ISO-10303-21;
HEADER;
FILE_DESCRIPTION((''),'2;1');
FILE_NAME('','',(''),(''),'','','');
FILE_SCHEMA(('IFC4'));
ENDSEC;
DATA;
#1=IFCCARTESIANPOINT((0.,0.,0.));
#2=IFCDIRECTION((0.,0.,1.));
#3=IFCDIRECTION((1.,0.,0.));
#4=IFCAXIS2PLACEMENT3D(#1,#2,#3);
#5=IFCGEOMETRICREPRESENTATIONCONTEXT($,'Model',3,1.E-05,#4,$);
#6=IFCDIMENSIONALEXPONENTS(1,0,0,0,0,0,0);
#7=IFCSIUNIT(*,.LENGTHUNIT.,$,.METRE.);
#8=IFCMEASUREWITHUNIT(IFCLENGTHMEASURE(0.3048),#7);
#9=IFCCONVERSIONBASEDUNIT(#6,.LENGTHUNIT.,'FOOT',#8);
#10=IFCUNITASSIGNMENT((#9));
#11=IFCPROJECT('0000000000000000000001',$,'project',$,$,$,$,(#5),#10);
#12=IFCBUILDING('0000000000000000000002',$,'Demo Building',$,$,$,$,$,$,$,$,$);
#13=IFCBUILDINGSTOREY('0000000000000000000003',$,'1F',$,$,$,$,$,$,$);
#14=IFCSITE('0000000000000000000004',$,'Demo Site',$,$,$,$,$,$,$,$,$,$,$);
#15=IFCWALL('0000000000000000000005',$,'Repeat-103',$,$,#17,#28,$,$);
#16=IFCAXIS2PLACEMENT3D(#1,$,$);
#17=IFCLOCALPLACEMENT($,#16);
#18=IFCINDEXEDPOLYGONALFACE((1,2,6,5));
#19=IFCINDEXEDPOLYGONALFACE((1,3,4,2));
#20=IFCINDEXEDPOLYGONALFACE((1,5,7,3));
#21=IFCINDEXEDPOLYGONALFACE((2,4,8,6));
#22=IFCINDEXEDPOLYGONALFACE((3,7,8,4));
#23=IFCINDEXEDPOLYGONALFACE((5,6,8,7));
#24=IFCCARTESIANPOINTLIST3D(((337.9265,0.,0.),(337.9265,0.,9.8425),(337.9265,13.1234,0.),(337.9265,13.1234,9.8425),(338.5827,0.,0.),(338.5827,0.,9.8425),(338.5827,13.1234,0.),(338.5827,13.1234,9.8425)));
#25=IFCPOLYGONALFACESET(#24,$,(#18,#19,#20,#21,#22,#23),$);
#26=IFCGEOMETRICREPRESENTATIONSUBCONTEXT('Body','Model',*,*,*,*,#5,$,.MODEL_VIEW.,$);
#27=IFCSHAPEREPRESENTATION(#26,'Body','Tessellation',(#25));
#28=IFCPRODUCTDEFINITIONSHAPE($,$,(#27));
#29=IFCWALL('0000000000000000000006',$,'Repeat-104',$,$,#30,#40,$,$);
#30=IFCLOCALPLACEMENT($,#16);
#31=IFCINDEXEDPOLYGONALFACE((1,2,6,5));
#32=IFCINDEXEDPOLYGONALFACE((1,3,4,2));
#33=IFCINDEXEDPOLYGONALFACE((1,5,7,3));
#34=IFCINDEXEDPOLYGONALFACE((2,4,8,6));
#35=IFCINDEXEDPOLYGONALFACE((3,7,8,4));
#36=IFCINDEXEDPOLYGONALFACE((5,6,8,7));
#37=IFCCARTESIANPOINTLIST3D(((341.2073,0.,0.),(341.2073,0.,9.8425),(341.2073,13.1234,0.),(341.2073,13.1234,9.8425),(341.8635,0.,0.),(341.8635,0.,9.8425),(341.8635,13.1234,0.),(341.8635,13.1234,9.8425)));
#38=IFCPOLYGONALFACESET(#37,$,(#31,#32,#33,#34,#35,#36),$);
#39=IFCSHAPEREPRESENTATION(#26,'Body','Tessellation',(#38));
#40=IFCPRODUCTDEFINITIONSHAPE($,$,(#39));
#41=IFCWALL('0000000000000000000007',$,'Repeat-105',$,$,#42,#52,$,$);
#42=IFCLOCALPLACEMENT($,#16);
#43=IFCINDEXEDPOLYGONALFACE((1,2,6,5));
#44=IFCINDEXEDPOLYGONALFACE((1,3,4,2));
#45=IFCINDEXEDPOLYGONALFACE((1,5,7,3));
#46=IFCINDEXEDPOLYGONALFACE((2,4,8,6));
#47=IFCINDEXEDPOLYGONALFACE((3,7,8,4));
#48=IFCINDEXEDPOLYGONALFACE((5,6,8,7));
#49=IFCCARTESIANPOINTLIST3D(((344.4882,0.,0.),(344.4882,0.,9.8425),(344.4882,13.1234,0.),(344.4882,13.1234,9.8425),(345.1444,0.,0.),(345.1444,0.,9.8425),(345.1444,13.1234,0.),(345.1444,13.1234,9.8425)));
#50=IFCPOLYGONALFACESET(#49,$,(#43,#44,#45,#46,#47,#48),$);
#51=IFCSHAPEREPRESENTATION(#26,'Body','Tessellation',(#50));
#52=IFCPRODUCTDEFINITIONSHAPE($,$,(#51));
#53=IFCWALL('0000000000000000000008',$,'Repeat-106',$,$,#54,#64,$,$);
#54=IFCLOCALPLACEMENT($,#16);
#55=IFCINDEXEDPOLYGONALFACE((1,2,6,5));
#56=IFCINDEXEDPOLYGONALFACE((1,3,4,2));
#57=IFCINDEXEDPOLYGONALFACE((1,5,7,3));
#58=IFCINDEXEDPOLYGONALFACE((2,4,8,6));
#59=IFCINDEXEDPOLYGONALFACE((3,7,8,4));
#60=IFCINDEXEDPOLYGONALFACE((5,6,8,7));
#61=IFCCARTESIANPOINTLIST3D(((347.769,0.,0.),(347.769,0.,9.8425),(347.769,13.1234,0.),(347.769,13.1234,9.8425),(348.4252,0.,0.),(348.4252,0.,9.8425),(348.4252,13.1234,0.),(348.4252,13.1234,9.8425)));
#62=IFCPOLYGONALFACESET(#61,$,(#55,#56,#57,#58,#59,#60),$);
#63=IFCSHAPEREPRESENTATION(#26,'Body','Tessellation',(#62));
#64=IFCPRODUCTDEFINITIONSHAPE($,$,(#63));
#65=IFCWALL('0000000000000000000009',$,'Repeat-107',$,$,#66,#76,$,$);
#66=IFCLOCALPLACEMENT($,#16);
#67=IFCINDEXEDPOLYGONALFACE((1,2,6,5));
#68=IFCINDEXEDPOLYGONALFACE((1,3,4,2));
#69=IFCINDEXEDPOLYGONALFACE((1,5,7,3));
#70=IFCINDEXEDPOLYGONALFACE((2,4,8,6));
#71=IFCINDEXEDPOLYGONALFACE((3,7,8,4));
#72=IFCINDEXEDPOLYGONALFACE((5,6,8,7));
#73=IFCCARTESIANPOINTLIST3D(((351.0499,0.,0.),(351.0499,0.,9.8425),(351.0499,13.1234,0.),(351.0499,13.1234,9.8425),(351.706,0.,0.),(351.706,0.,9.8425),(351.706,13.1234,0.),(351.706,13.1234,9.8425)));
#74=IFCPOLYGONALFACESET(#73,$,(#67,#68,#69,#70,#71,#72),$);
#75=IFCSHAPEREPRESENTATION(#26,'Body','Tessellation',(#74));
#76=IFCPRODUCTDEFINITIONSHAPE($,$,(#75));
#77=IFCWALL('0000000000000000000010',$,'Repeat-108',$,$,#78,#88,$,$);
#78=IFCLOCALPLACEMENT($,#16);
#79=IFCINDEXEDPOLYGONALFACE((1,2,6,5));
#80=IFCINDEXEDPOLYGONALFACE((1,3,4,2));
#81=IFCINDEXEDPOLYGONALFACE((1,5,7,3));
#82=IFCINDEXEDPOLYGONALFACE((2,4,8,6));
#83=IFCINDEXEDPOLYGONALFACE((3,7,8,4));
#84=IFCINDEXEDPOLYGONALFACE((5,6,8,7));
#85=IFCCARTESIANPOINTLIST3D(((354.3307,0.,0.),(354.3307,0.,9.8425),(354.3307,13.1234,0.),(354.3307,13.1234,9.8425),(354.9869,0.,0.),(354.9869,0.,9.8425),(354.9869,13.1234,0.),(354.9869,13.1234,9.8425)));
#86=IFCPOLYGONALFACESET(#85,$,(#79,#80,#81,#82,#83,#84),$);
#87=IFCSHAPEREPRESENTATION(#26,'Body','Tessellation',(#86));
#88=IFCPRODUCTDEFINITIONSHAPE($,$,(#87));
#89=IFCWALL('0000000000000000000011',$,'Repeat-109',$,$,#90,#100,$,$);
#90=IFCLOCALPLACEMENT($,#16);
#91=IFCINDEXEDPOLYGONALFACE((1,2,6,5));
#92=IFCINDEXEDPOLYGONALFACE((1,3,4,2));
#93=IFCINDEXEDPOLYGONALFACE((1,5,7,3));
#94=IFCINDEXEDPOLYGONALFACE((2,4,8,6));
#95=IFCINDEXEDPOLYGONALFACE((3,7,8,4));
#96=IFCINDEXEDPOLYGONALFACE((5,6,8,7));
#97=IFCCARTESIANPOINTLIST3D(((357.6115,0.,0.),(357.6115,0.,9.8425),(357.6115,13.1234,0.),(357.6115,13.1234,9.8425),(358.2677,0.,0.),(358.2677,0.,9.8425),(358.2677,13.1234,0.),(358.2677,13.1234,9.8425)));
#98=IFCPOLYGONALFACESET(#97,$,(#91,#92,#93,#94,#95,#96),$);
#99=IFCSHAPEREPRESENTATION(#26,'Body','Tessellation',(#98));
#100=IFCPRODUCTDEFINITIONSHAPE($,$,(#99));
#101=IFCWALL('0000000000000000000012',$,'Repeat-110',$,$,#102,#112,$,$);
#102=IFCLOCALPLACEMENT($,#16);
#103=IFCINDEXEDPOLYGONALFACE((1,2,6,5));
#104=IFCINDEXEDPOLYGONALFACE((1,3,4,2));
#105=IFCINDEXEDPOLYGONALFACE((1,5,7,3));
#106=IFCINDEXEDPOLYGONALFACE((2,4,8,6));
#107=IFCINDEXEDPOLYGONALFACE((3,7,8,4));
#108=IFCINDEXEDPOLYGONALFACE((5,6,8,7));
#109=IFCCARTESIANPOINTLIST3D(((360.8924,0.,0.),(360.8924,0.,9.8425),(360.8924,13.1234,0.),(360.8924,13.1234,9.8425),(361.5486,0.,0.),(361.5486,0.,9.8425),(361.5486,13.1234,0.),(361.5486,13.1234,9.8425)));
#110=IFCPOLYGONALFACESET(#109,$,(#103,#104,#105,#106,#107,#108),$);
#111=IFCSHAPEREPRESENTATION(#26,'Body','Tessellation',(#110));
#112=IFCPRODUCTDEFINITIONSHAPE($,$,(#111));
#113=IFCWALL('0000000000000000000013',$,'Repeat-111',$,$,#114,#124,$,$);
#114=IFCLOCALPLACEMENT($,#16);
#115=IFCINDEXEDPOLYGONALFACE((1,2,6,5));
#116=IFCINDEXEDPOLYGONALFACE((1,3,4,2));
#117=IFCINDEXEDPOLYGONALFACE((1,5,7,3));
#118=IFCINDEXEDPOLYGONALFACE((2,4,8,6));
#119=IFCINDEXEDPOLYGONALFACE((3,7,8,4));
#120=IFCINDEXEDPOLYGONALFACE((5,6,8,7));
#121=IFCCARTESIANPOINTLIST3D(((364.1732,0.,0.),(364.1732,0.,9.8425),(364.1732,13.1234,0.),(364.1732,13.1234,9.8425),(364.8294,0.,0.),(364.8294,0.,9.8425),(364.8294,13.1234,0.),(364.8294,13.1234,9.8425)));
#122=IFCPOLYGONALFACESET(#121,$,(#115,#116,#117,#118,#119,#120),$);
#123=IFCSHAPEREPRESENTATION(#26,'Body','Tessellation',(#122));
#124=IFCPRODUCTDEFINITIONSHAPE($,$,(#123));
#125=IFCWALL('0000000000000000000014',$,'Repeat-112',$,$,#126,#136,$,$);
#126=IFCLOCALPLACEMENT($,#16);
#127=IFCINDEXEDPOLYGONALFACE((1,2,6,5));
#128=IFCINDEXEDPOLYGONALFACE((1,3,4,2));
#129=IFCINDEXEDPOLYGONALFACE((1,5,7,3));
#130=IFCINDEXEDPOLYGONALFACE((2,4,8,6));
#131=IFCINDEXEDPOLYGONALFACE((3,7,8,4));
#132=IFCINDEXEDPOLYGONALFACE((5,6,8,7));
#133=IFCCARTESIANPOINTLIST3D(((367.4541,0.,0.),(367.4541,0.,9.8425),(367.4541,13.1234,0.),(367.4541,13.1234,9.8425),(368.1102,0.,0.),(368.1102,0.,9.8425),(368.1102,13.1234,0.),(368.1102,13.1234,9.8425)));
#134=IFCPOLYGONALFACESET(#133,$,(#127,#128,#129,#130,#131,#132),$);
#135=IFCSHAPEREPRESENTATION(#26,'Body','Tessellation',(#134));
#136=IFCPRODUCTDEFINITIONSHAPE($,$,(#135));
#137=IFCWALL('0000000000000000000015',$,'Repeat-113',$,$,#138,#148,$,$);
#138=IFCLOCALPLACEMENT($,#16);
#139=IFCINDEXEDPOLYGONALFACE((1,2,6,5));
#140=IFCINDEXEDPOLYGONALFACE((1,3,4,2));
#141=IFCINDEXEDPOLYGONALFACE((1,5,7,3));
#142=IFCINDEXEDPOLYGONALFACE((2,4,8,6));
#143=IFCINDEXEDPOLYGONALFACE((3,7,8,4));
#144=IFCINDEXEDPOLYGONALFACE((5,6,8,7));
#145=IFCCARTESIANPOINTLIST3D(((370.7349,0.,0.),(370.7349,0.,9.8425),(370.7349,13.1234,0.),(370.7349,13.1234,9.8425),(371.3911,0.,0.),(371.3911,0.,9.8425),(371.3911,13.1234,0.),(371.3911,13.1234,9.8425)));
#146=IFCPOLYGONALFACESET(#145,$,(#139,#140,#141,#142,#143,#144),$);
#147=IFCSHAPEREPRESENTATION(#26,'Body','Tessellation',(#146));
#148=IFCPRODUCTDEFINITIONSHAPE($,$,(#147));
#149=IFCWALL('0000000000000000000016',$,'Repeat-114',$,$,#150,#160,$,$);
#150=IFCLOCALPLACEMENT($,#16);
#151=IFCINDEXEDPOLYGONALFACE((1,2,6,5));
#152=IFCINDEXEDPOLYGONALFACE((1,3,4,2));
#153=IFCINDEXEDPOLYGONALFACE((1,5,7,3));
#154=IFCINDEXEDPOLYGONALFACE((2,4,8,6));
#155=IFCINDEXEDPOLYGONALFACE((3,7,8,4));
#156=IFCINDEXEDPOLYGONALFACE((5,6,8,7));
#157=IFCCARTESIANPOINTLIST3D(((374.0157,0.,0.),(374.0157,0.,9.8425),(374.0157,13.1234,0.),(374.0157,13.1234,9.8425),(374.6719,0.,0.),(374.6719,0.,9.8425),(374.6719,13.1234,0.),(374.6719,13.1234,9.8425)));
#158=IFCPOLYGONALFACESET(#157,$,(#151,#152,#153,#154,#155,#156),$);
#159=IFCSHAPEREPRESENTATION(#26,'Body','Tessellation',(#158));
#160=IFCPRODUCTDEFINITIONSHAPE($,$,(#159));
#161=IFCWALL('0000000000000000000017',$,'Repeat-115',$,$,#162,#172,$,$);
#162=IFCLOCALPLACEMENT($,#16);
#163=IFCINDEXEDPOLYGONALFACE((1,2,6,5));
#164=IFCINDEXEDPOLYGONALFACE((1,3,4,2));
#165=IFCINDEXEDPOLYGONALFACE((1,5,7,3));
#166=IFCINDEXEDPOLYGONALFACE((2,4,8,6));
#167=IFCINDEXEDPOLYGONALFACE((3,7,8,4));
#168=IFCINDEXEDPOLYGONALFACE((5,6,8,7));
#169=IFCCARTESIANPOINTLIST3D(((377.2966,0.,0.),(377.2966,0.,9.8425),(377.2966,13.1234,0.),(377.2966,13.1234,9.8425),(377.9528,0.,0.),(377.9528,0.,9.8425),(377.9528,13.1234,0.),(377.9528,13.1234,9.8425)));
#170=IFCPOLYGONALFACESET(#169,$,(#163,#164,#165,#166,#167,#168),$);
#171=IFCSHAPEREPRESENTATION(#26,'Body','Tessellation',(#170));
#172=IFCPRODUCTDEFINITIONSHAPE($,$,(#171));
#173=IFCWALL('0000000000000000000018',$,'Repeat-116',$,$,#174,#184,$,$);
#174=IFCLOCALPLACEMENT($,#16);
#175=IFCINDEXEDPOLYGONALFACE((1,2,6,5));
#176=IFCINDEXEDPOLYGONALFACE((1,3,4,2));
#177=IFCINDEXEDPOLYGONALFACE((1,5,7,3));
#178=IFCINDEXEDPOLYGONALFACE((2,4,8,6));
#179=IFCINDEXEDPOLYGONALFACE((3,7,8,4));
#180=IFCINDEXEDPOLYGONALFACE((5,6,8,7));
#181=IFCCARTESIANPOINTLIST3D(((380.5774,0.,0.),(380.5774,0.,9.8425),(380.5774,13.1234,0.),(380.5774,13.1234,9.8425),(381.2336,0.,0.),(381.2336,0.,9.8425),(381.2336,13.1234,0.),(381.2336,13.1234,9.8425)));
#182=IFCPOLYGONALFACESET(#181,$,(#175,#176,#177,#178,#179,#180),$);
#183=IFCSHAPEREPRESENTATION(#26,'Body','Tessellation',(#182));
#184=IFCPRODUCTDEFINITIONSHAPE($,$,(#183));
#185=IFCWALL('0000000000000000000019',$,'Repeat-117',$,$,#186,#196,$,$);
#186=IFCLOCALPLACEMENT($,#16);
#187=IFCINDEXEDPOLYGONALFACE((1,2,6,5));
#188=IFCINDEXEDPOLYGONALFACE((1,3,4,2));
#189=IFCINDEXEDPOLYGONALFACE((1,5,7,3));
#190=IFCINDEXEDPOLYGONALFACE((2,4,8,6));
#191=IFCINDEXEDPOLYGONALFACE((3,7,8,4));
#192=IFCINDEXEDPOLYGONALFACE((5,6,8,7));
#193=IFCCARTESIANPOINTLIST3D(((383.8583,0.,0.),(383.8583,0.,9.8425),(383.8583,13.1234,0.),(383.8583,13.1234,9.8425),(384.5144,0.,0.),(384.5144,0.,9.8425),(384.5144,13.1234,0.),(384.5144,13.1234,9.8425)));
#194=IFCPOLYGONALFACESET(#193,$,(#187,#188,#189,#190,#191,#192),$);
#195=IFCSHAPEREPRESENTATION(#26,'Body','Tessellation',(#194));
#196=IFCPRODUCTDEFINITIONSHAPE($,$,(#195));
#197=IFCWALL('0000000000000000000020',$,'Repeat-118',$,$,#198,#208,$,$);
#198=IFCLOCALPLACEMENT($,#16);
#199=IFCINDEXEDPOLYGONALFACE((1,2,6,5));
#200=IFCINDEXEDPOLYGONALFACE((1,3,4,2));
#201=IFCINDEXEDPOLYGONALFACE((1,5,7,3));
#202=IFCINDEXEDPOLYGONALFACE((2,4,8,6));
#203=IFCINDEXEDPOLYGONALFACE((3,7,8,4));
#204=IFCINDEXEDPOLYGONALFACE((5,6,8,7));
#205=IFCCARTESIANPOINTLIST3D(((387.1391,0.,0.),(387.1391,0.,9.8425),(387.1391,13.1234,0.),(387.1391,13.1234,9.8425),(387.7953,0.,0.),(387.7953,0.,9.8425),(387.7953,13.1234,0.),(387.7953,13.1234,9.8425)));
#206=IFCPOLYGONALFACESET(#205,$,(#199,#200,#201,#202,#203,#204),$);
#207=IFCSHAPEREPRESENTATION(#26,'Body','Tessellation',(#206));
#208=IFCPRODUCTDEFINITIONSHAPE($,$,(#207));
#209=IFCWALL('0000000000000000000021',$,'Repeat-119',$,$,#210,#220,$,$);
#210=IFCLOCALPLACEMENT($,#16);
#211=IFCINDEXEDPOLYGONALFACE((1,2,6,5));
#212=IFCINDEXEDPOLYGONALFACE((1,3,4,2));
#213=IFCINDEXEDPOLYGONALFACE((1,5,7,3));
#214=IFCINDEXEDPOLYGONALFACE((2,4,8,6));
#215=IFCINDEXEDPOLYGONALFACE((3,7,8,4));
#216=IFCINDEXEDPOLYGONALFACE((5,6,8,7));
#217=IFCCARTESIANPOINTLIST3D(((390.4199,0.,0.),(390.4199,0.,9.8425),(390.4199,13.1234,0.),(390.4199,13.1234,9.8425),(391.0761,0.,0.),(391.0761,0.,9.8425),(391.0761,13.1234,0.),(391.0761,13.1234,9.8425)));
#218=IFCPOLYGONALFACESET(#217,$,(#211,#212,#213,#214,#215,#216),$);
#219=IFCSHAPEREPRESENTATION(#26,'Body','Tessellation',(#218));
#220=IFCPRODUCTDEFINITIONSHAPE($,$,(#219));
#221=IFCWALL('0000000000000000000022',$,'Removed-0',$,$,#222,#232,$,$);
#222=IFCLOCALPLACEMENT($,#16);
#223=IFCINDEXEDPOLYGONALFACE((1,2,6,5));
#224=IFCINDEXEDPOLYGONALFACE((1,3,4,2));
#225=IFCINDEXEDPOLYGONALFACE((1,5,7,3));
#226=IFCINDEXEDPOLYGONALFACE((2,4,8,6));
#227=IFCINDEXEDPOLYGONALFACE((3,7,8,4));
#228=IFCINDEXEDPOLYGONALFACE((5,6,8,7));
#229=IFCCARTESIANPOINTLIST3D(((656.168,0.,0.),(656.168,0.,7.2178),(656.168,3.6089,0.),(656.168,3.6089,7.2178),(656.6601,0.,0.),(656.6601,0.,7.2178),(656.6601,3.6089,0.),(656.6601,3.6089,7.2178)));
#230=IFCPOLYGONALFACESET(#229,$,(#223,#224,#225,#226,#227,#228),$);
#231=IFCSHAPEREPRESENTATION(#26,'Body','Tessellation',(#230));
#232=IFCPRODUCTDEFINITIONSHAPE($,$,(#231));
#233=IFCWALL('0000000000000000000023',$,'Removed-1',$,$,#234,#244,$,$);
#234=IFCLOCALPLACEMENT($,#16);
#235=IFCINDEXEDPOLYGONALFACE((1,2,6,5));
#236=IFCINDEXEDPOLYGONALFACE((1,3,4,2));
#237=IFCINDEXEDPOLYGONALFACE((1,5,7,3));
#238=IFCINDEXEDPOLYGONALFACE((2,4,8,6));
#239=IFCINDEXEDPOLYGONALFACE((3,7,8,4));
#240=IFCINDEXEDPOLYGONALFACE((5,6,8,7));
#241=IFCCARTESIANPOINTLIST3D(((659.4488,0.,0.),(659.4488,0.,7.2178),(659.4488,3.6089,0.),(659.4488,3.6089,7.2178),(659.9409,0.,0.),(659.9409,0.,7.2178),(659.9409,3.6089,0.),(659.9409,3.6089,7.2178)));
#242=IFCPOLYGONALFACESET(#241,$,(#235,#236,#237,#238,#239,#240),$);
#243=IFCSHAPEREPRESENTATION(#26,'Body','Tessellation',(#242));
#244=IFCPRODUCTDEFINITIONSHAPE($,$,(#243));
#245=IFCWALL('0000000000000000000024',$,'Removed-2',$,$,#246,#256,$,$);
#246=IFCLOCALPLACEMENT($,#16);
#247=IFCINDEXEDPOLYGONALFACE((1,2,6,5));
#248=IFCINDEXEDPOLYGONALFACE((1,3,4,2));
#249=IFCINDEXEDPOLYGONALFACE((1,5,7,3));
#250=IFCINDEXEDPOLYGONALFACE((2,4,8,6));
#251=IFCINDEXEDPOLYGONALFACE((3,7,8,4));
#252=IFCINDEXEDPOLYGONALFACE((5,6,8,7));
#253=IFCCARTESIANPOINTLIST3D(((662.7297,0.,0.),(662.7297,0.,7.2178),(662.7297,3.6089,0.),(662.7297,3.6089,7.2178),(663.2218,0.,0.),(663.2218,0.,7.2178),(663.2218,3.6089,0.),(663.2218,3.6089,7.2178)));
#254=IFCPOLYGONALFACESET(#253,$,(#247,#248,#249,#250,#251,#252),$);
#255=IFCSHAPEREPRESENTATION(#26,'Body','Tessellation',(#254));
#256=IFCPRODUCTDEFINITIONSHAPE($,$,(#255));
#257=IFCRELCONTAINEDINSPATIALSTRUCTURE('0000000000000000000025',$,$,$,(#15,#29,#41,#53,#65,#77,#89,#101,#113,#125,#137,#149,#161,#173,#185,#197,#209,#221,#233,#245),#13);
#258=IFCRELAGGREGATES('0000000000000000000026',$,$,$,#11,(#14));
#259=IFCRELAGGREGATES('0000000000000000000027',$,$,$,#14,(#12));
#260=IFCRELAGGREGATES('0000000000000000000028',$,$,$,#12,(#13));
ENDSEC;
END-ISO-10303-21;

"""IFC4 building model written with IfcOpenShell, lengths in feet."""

from ifc_helpers import new_model, entity, si_unit, converted_unit, frame, origin_with_axes, place, context, subcontext, project, spatial, element, save


model = new_model("IFC4")

# Units and contexts
model_context = context("Model", 3, precision=1e-05, world=origin_with_axes())
body_context = subcontext(model_context, "Body", "Model", "MODEL_VIEW")
ifc_project = project(units=[converted_unit("LENGTHUNIT", "FOOT", entity("IfcLengthMeasure", 0.3048), si_unit("LENGTHUNIT", "METRE"), dimensions=[1, 0, 0, 0, 0, 0, 0])], contexts=[model_context])

# Site, building, storey
site = spatial("IfcSite", under=ifc_project, Name="Demo Site")
building = spatial("IfcBuilding", under=site, Name="Demo Building")
storey = spatial("IfcBuildingStorey", under=building, Name="1F")

# Walls
for number, where, z_axis, x_axis, name in (
    (1, (337.9265, 0.0, 0.0), (0.0, 0.0, 1.0), (1.0, 0.0, 0.0), "Repeat-103"),
    (2, (341.2073, 0.0, 0.0), (0.0, 0.0, 1.0), (1.0, 0.0, 0.0), "Repeat-104"),
    (3, (344.4882, 0.0, 0.0), (0.0, 0.0, 1.0), (1.0, 0.0, 0.0), "Repeat-105"),
    (4, (347.769, 0.0, 0.0), (0.0, 0.0, 1.0), (1.0, 0.0, 0.0), "Repeat-106"),
    (5, (351.0499, 0.0, 0.0), (0.0, 0.0, 1.0), (1.0, 0.0, 0.0), "Repeat-107"),
    (6, (354.3307, 0.0, 0.0), (0.0, 0.0, 1.0), (1.0, 0.0, 0.0), "Repeat-108"),
    (7, (357.6115, 0.0, 0.0), (0.0, 0.0, 1.0), (1.0, 0.0, 0.0), "Repeat-109"),
    (8, (360.8924, 0.0, 0.0), (0.0, 0.0, 1.0), (1.0, 0.0, 0.0), "Repeat-110"),
    (9, (364.1732, 0.0, 0.0), (0.0, 0.0, 1.0), (1.0, 0.0, 0.0), "Repeat-111"),
    (10, (367.4541, 0.0, 0.0), (0.0, 0.0, 1.0), (1.0, 0.0, 0.0), "Repeat-112"),
    (11, (370.7349, 0.0, 0.0), (0.0, 0.0, 1.0), (1.0, 0.0, 0.0), "Repeat-113"),
    (12, (374.0157, 0.0, 0.0), (0.0, 0.0, 1.0), (1.0, 0.0, 0.0), "Repeat-114"),
    (13, (377.2966, 0.0, 0.0), (0.0, 0.0, 1.0), (1.0, 0.0, 0.0), "Repeat-115"),
    (14, (380.5774, 0.0, 0.0), (0.0, 0.0, 1.0), (1.0, 0.0, 0.0), "Repeat-116"),
    (15, (383.8583, 0.0, 0.0), (0.0, 0.0, 1.0), (1.0, 0.0, 0.0), "Repeat-117"),
    (16, (387.1391, 0.0, 0.0), (0.0, 0.0, 1.0), (1.0, 0.0, 0.0), "Repeat-118"),
    (17, (390.4199, 0.0, 0.0), (0.0, 0.0, 1.0), (1.0, 0.0, 0.0), "Repeat-119"),
):
    element("IfcWall", number, at=place(None, frame(where, z_axis=z_axis, x_axis=x_axis)), inside=storey, Name=name, context=body_context, shape_type="CSG", body=[
        entity("IfcBlock", entity("IfcAxis2Placement3D", entity("IfcCartesianPoint", [0.0, 0.0, 0.0]), entity("IfcDirection", [0.0, 0.0, 1.0]), entity("IfcDirection", [1.0, 0.0, 0.0])), 0.6562, 13.1234, 9.8425),
    ])
for number, where, z_axis, x_axis, name in (
    (18, (656.168, 0.0, 0.0), (0.0, 0.0, 1.0), (1.0, 0.0, 0.0), "Removed-0"),
    (19, (659.4488, 0.0, 0.0), (0.0, 0.0, 1.0), (1.0, 0.0, 0.0), "Removed-1"),
    (20, (662.7297, 0.0, 0.0), (0.0, 0.0, 1.0), (1.0, 0.0, 0.0), "Removed-2"),
):
    element("IfcWall", number, at=place(None, frame(where, z_axis=z_axis, x_axis=x_axis)), inside=storey, Name=name, context=body_context, shape_type="CSG", body=[
        entity("IfcBlock", entity("IfcAxis2Placement3D", entity("IfcCartesianPoint", [0.0, 0.0, 0.0]), entity("IfcDirection", [0.0, 0.0, 1.0]), entity("IfcDirection", [1.0, 0.0, 0.0])), 0.4921, 3.6089, 7.2178),
    ])

save(model, "model.ifc")
